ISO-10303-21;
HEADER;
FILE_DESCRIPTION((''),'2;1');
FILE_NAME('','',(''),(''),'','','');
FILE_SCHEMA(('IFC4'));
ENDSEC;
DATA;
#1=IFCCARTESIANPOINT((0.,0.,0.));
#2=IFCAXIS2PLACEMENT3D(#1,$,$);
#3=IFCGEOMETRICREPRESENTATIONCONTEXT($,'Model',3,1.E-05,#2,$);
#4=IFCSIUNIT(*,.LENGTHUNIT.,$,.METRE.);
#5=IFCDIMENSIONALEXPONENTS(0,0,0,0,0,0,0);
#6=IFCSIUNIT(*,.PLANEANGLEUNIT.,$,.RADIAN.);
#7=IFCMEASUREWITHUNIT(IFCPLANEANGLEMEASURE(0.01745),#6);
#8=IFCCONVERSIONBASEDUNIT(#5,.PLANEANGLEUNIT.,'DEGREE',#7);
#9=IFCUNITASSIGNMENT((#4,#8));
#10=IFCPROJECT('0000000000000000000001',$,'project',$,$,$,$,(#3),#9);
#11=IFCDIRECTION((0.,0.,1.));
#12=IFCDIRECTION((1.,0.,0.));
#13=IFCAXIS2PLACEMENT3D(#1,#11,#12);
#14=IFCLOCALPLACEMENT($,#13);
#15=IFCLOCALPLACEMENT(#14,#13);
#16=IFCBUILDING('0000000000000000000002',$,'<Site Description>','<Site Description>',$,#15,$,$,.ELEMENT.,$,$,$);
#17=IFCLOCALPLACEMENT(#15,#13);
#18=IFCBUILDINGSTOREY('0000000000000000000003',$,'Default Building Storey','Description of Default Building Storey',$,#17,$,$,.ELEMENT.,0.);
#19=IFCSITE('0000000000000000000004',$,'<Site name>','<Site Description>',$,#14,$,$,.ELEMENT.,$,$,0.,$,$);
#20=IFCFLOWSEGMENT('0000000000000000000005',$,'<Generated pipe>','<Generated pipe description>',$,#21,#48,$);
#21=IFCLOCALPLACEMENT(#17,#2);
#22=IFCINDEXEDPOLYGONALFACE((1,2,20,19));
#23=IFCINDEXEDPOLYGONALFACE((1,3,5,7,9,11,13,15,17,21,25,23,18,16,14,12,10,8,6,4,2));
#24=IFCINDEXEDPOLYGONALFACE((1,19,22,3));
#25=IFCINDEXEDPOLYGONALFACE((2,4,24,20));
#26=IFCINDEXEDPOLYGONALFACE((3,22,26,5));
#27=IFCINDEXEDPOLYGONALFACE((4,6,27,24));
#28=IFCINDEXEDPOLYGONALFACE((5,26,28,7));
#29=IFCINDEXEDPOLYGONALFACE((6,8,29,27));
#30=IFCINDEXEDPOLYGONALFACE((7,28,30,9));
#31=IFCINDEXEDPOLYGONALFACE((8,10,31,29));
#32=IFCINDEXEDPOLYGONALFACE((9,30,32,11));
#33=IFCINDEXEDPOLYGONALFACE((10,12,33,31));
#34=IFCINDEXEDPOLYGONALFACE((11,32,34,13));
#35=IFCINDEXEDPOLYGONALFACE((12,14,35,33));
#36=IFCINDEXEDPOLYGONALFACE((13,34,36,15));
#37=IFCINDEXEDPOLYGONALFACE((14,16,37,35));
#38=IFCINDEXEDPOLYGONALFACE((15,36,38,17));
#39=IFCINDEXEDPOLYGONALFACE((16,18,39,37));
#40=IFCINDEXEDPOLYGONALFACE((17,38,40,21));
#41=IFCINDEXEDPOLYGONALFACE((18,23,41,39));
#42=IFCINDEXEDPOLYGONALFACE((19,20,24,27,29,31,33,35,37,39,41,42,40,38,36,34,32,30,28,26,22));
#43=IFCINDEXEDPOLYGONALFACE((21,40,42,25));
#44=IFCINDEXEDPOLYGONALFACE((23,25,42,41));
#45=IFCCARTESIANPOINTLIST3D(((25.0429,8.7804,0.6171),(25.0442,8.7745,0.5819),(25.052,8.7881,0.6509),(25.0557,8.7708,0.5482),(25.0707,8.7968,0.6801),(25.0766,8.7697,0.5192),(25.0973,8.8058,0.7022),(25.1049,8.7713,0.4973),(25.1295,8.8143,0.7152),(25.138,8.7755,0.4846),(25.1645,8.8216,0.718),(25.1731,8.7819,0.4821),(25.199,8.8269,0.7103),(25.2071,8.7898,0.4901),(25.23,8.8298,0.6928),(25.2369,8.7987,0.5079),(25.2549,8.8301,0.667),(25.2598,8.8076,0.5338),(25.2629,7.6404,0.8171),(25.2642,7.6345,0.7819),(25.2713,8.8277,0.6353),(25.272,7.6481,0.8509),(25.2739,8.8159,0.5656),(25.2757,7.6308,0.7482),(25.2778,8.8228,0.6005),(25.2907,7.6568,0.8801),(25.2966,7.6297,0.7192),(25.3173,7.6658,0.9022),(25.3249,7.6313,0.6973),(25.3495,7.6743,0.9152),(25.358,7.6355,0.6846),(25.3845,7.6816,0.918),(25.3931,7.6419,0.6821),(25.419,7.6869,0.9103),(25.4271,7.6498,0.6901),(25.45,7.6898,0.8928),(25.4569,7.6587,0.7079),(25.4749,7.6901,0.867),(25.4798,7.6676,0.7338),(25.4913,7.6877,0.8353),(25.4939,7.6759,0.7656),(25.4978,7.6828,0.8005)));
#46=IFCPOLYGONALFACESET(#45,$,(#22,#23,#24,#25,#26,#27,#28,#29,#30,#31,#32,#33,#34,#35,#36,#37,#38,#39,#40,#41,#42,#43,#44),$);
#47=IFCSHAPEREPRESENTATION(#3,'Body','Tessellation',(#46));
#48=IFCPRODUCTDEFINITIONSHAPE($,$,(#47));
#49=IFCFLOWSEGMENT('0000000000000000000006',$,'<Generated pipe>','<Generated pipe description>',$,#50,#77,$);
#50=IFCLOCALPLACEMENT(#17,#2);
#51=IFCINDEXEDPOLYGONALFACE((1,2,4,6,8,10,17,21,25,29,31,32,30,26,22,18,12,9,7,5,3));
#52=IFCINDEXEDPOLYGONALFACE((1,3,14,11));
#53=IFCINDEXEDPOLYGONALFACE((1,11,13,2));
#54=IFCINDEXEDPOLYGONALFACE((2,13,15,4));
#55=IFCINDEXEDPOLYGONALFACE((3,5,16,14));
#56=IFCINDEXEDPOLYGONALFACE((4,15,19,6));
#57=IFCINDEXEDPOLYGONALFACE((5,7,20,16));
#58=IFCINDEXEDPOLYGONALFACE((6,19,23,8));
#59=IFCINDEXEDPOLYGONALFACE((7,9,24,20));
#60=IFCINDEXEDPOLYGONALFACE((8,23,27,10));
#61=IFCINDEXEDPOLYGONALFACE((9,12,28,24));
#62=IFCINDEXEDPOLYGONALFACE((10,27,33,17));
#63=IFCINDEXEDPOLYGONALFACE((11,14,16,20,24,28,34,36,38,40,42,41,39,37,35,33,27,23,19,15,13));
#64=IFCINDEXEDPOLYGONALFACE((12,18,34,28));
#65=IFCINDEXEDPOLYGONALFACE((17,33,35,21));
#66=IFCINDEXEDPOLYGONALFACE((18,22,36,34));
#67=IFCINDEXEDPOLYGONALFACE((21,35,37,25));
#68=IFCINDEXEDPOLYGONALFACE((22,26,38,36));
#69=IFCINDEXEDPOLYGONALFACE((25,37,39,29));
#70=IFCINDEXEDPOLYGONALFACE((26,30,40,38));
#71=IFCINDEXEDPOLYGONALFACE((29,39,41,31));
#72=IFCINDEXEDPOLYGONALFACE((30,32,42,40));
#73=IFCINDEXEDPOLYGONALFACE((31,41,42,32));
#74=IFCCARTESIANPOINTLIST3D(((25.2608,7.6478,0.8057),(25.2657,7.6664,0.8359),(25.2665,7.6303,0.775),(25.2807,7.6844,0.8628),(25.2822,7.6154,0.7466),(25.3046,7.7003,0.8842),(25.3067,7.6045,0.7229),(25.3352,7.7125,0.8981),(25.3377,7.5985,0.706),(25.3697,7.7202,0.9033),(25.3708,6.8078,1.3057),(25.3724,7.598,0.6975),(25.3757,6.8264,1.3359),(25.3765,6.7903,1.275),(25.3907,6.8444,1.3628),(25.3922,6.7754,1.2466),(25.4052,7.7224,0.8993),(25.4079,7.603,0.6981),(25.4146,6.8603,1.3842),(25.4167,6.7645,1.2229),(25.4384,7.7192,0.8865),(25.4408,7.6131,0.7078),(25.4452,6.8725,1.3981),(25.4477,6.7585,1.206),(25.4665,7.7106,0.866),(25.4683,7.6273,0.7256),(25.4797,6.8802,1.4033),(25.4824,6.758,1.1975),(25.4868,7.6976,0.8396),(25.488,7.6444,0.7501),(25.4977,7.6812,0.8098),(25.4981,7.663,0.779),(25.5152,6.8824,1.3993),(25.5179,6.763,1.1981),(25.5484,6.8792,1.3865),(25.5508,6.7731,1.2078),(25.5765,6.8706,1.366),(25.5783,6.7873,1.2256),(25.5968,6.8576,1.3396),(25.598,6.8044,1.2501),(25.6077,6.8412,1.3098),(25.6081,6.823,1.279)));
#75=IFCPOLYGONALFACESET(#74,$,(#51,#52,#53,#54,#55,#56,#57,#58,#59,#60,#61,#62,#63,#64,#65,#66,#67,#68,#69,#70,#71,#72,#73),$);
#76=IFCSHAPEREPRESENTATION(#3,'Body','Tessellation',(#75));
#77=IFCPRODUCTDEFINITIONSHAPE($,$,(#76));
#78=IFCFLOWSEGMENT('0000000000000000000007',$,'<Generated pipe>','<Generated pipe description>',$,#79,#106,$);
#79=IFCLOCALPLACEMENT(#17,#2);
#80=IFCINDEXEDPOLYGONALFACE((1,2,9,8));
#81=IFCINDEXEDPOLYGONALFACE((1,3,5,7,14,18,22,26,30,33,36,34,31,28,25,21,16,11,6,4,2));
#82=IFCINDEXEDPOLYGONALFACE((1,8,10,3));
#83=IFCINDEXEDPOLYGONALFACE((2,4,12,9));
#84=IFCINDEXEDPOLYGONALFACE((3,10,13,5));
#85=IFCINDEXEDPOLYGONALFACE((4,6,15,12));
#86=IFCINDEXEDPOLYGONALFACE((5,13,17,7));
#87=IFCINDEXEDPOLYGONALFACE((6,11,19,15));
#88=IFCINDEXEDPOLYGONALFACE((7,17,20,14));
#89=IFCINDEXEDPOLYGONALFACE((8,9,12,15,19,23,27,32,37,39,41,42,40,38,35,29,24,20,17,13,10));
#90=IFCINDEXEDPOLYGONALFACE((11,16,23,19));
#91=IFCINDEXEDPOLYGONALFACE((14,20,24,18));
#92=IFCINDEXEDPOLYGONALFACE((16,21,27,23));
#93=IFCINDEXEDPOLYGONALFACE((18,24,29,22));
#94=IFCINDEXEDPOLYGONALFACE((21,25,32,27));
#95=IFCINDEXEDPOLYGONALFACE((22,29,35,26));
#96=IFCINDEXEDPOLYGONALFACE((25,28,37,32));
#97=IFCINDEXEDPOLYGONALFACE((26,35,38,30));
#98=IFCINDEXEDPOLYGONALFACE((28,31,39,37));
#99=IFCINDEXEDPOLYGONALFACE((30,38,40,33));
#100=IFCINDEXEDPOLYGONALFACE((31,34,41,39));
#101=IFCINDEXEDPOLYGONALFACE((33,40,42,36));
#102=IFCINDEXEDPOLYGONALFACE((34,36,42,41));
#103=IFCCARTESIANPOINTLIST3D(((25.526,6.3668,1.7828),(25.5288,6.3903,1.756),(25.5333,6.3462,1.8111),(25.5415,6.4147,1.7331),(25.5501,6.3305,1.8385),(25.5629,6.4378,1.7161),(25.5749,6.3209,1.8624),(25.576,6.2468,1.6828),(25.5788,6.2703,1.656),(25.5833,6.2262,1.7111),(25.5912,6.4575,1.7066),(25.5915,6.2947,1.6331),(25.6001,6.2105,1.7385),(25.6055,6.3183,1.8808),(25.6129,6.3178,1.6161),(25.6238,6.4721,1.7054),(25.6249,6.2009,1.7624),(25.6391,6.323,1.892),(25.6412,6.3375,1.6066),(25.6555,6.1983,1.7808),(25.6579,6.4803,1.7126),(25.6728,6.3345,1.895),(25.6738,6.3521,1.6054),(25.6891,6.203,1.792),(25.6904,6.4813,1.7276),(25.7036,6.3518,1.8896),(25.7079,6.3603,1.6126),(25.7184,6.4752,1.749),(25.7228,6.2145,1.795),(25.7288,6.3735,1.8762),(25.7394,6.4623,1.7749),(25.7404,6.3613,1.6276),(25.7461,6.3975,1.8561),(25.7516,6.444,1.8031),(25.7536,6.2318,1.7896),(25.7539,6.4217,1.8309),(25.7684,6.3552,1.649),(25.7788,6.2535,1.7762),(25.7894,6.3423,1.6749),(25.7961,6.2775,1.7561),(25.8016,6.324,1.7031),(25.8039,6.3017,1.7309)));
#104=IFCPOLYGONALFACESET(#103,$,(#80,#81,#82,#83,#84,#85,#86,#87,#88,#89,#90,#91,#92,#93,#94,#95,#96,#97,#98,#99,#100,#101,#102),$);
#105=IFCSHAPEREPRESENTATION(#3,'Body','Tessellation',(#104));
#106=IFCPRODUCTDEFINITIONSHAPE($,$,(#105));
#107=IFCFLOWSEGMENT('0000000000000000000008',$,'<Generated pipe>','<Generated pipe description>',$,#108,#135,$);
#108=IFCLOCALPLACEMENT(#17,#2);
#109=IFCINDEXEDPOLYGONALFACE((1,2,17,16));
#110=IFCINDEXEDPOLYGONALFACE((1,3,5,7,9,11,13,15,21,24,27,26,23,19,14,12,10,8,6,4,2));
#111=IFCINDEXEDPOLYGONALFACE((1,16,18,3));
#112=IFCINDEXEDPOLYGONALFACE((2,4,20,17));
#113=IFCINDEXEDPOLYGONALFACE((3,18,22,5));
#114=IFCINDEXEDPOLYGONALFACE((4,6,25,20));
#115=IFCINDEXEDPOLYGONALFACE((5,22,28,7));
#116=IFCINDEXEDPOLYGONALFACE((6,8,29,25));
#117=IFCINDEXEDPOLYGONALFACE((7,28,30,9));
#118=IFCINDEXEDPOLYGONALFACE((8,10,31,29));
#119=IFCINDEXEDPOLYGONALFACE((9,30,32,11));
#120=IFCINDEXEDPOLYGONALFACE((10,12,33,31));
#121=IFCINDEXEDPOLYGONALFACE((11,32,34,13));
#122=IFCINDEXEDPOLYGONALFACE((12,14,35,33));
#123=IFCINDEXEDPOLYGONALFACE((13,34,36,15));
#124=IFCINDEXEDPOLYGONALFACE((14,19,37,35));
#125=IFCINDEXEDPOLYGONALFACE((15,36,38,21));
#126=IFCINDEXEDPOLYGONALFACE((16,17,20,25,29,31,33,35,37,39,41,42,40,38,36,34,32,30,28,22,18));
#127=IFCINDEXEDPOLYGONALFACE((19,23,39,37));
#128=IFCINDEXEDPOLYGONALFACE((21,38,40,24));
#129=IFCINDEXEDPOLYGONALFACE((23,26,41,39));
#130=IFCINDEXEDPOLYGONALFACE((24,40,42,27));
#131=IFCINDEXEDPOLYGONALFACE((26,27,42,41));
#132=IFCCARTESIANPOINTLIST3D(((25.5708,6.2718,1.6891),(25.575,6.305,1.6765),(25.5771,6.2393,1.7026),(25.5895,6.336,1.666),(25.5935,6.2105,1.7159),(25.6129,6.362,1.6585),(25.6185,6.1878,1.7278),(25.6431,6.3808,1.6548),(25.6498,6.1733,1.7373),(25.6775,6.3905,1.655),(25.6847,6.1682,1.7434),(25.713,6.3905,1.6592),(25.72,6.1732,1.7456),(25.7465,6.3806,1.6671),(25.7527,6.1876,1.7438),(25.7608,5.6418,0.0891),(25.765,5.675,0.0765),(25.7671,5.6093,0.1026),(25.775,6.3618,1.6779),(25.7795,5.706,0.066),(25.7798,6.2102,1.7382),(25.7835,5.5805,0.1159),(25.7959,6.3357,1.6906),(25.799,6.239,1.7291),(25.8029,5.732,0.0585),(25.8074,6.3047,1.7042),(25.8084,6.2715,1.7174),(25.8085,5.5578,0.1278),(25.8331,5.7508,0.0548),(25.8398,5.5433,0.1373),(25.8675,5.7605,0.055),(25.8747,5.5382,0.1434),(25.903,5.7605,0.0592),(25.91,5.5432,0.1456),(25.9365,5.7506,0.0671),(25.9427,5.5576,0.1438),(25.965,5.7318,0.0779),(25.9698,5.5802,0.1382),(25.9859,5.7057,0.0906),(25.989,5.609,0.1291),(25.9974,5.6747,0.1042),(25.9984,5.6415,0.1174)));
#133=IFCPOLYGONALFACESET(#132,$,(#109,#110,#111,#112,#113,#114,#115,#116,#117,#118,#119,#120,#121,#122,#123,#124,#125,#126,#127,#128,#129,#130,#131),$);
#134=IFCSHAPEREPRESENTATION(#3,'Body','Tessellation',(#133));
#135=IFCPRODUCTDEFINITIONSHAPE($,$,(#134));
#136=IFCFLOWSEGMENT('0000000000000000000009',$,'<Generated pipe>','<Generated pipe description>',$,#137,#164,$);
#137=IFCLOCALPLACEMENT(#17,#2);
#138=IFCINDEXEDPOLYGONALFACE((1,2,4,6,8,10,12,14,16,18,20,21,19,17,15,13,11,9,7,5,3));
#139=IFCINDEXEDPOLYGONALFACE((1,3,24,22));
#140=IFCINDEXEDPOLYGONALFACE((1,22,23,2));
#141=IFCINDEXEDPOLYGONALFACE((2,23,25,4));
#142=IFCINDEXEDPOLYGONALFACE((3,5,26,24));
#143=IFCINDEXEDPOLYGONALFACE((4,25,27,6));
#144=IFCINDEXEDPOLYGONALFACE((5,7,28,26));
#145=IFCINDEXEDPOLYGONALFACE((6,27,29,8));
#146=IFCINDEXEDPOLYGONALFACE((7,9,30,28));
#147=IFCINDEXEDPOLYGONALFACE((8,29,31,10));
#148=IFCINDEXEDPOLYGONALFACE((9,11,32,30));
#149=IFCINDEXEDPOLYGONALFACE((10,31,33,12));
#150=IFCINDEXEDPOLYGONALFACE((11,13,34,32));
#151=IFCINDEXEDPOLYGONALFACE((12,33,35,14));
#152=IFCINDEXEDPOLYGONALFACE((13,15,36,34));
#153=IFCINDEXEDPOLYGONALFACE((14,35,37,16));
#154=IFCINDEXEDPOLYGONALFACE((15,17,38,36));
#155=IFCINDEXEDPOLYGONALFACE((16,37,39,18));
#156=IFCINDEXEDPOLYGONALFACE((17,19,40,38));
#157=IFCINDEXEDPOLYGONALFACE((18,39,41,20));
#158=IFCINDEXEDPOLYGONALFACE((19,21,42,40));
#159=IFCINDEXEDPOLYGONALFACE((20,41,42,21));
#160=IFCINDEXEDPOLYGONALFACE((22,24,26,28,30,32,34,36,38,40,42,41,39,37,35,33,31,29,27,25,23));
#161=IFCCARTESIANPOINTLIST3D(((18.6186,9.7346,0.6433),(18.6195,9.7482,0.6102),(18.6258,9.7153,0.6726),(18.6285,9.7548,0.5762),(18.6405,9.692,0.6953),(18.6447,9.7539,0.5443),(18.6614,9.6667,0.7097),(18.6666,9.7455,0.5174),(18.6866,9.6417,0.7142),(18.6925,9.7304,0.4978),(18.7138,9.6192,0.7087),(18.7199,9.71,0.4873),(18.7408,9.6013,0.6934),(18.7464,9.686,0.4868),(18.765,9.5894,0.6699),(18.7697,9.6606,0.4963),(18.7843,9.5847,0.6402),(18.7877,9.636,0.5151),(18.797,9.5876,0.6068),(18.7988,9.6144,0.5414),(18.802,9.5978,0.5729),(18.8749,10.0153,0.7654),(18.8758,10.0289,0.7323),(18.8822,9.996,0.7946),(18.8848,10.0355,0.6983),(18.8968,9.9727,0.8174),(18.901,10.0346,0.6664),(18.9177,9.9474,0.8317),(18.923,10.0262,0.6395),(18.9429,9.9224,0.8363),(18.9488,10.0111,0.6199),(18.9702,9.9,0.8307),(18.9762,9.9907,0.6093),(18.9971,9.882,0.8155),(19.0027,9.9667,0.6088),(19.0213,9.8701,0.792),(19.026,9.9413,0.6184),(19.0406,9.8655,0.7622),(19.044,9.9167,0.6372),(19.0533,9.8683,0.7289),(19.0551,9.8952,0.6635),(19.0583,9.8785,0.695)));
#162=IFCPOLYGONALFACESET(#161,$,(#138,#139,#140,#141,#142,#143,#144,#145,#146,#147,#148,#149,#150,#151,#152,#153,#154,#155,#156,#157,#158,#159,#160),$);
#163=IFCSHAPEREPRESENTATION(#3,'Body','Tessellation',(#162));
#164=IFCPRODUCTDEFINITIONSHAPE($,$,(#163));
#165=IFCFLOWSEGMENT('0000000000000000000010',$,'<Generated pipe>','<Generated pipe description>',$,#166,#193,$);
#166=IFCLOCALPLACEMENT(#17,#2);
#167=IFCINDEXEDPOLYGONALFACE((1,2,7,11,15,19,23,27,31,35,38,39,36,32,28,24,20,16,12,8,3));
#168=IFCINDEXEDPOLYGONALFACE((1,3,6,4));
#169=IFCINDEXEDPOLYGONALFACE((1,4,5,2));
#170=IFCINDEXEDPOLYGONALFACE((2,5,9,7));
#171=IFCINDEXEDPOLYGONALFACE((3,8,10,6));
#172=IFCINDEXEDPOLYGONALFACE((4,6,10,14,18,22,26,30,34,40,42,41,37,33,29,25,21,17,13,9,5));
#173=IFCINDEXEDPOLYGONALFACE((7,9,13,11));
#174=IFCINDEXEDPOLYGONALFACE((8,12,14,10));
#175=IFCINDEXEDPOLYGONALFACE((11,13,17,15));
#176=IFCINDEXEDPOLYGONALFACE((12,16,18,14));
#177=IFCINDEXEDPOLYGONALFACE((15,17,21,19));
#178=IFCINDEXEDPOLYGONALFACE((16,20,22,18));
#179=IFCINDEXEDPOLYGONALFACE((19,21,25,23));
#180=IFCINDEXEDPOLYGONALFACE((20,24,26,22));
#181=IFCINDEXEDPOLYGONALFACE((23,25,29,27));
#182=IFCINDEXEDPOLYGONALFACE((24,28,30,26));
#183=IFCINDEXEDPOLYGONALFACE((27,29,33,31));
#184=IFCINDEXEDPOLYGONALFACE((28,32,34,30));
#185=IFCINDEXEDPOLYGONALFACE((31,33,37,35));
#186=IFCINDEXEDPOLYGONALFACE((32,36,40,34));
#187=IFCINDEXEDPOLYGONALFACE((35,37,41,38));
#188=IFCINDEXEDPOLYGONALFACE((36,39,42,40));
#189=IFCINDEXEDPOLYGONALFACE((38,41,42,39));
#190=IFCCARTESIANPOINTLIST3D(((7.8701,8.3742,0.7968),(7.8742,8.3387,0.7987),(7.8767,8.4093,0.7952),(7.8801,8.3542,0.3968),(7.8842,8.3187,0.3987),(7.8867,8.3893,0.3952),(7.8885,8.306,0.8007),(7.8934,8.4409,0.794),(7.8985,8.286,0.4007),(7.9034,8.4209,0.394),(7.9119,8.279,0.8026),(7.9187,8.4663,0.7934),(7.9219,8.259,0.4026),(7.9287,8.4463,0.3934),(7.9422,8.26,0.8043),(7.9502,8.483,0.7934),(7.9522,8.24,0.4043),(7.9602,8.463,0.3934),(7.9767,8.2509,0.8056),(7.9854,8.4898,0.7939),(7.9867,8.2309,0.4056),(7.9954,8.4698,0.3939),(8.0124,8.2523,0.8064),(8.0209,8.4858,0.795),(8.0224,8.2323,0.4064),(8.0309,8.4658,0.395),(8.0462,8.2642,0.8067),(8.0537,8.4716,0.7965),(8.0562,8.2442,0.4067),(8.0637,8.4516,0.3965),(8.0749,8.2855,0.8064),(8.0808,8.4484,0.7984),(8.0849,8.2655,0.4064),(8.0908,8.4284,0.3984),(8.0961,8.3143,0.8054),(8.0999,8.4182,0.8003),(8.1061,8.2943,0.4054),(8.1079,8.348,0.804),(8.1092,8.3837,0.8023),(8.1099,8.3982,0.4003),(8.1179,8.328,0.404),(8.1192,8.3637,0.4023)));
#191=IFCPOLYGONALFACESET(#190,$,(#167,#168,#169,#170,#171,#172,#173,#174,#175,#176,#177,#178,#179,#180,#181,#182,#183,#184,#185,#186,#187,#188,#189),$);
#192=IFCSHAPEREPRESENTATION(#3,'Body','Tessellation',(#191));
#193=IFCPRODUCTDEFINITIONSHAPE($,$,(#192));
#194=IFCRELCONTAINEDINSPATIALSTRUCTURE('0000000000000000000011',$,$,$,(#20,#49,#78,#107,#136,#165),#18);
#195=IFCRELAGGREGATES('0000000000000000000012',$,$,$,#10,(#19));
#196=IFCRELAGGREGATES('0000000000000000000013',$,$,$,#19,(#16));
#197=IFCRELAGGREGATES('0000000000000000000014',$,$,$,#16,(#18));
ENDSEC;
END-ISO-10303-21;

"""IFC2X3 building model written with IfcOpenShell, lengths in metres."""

from ifc_helpers import new_model, entity, si_unit, converted_unit, frame, origin, origin_with_axes, origin_2d_with_axis, place, context, project, spatial, circle, extrude, element, save


model = new_model("IFC2X3")

# Units and contexts
model_context = context("Model", 3, precision=1e-05, world=origin())
ifc_project = project(units=[si_unit("LENGTHUNIT", "METRE"), converted_unit("PLANEANGLEUNIT", "DEGREE", entity("IfcPlaneAngleMeasure", 0.01745), si_unit("PLANEANGLEUNIT", "RADIAN"), dimensions=[0, 0, 0, 0, 0, 0, 0])], contexts=[model_context])

# Site, building, storey
site_placement = place(None, origin_with_axes())
site = spatial("IfcSite", under=ifc_project, at=site_placement, Name="<Site name>", Description="<Site Description>", CompositionType="ELEMENT", RefElevation=0.0)
building_placement = place(site_placement, origin_with_axes())
building = spatial("IfcBuilding", under=site, at=building_placement, Name="<Site Description>", Description="<Site Description>", CompositionType="ELEMENT")
storey_placement = place(building_placement, origin_with_axes())
storey = spatial("IfcBuildingStorey", under=building, at=storey_placement, Name="Default Building Storey", Description="Description of Default Building Storey", CompositionType="ELEMENT", Elevation=0.0)

# Flow segments
flow_segment_1_placement = place(storey_placement, frame((25.16, 8.8, 0.6), z_axis=(0.186736, -0.967632, 0.16976), x_axis=(0.790715, 0.250585, 0.558549)))
element("IfcFlowSegment", 1, at=flow_segment_1_placement, inside=storey, Name="<Generated pipe>", Description="<Generated pipe description>", context=model_context, shape_type="SweptSolid", body=[
    extrude(circle(Radius=0.12, at=origin_2d_with_axis()), origin_with_axes(), (0.0, 0.0, 1.0), 1.1781),
])
flow_segment_2_placement = place(storey_placement, frame((25.38, 7.66, 0.8), z_axis=(0.111821, -0.853904, 0.508276), x_axis=(0.487046, 0.492932, 0.720975)))
element("IfcFlowSegment", 2, at=flow_segment_2_placement, inside=storey, Name="<Generated pipe>", Description="<Generated pipe description>", context=model_context, shape_type="SweptSolid", body=[
    extrude(circle(Radius=0.12, at=origin_2d_with_axis()), origin_with_axes(), (0.0, 0.0, 1.0), 0.9837),
])
flow_segment_3_placement = place(storey_placement, frame((25.64, 6.4, 1.8), z_axis=(0.304855, -0.731653, -0.609711), x_axis=(0.88385, -0.02114, 0.467293)))
element("IfcFlowSegment", 3, at=flow_segment_3_placement, inside=storey, Name="<Generated pipe>", Description="<Generated pipe description>", context=model_context, shape_type="SweptSolid", body=[
    extrude(circle(Radius=0.12, at=origin_2d_with_axis()), origin_with_axes(), (0.0, 0.0, 1.0), 0.164),
])
flow_segment_4_placement = place(storey_placement, frame((25.69, 6.28, 1.7), z_axis=(0.109825, -0.364156, -0.92484), x_axis=(0.708002, 0.681724, -0.184353)))
element("IfcFlowSegment", 4, at=flow_segment_4_placement, inside=storey, Name="<Generated pipe>", Description="<Generated pipe description>", context=model_context, shape_type="SweptSolid", body=[
    extrude(circle(Radius=0.12, at=origin_2d_with_axis()), origin_with_axes(), (0.0, 0.0, 1.0), 1.73),
])
flow_segment_5_placement = place(storey_placement, frame((18.9663, 9.9507, 0.7221), z_axis=(-0.641989, -0.703131, -0.305709), x_axis=(0.766298, -0.60157, -0.225613)))
element("IfcFlowSegment", 5, at=flow_segment_5_placement, inside=storey, Name="<Generated pipe>", Description="<Generated pipe description>", context=model_context, shape_type="SweptSolid", body=[
    extrude(circle(Radius=0.12, at=origin_2d_with_axis()), origin_with_axes(), (0.0, 0.0, 1.0), 0.3993),
])
flow_segment_6_placement = place(storey_placement, frame((7.99, 8.37, 0.8), z_axis=(0.024961, -0.049922, -0.998441), x_axis=(0.756967, 0.653309, -0.013741)))
element("IfcFlowSegment", 6, at=flow_segment_6_placement, inside=storey, Name="<Generated pipe>", Description="<Generated pipe description>", context=model_context, shape_type="SweptSolid", body=[
    extrude(circle(Radius=0.12, at=origin_2d_with_axis()), origin_with_axes(), (0.0, 0.0, 1.0), 0.4006),
])

save(model, "model.ifc")
